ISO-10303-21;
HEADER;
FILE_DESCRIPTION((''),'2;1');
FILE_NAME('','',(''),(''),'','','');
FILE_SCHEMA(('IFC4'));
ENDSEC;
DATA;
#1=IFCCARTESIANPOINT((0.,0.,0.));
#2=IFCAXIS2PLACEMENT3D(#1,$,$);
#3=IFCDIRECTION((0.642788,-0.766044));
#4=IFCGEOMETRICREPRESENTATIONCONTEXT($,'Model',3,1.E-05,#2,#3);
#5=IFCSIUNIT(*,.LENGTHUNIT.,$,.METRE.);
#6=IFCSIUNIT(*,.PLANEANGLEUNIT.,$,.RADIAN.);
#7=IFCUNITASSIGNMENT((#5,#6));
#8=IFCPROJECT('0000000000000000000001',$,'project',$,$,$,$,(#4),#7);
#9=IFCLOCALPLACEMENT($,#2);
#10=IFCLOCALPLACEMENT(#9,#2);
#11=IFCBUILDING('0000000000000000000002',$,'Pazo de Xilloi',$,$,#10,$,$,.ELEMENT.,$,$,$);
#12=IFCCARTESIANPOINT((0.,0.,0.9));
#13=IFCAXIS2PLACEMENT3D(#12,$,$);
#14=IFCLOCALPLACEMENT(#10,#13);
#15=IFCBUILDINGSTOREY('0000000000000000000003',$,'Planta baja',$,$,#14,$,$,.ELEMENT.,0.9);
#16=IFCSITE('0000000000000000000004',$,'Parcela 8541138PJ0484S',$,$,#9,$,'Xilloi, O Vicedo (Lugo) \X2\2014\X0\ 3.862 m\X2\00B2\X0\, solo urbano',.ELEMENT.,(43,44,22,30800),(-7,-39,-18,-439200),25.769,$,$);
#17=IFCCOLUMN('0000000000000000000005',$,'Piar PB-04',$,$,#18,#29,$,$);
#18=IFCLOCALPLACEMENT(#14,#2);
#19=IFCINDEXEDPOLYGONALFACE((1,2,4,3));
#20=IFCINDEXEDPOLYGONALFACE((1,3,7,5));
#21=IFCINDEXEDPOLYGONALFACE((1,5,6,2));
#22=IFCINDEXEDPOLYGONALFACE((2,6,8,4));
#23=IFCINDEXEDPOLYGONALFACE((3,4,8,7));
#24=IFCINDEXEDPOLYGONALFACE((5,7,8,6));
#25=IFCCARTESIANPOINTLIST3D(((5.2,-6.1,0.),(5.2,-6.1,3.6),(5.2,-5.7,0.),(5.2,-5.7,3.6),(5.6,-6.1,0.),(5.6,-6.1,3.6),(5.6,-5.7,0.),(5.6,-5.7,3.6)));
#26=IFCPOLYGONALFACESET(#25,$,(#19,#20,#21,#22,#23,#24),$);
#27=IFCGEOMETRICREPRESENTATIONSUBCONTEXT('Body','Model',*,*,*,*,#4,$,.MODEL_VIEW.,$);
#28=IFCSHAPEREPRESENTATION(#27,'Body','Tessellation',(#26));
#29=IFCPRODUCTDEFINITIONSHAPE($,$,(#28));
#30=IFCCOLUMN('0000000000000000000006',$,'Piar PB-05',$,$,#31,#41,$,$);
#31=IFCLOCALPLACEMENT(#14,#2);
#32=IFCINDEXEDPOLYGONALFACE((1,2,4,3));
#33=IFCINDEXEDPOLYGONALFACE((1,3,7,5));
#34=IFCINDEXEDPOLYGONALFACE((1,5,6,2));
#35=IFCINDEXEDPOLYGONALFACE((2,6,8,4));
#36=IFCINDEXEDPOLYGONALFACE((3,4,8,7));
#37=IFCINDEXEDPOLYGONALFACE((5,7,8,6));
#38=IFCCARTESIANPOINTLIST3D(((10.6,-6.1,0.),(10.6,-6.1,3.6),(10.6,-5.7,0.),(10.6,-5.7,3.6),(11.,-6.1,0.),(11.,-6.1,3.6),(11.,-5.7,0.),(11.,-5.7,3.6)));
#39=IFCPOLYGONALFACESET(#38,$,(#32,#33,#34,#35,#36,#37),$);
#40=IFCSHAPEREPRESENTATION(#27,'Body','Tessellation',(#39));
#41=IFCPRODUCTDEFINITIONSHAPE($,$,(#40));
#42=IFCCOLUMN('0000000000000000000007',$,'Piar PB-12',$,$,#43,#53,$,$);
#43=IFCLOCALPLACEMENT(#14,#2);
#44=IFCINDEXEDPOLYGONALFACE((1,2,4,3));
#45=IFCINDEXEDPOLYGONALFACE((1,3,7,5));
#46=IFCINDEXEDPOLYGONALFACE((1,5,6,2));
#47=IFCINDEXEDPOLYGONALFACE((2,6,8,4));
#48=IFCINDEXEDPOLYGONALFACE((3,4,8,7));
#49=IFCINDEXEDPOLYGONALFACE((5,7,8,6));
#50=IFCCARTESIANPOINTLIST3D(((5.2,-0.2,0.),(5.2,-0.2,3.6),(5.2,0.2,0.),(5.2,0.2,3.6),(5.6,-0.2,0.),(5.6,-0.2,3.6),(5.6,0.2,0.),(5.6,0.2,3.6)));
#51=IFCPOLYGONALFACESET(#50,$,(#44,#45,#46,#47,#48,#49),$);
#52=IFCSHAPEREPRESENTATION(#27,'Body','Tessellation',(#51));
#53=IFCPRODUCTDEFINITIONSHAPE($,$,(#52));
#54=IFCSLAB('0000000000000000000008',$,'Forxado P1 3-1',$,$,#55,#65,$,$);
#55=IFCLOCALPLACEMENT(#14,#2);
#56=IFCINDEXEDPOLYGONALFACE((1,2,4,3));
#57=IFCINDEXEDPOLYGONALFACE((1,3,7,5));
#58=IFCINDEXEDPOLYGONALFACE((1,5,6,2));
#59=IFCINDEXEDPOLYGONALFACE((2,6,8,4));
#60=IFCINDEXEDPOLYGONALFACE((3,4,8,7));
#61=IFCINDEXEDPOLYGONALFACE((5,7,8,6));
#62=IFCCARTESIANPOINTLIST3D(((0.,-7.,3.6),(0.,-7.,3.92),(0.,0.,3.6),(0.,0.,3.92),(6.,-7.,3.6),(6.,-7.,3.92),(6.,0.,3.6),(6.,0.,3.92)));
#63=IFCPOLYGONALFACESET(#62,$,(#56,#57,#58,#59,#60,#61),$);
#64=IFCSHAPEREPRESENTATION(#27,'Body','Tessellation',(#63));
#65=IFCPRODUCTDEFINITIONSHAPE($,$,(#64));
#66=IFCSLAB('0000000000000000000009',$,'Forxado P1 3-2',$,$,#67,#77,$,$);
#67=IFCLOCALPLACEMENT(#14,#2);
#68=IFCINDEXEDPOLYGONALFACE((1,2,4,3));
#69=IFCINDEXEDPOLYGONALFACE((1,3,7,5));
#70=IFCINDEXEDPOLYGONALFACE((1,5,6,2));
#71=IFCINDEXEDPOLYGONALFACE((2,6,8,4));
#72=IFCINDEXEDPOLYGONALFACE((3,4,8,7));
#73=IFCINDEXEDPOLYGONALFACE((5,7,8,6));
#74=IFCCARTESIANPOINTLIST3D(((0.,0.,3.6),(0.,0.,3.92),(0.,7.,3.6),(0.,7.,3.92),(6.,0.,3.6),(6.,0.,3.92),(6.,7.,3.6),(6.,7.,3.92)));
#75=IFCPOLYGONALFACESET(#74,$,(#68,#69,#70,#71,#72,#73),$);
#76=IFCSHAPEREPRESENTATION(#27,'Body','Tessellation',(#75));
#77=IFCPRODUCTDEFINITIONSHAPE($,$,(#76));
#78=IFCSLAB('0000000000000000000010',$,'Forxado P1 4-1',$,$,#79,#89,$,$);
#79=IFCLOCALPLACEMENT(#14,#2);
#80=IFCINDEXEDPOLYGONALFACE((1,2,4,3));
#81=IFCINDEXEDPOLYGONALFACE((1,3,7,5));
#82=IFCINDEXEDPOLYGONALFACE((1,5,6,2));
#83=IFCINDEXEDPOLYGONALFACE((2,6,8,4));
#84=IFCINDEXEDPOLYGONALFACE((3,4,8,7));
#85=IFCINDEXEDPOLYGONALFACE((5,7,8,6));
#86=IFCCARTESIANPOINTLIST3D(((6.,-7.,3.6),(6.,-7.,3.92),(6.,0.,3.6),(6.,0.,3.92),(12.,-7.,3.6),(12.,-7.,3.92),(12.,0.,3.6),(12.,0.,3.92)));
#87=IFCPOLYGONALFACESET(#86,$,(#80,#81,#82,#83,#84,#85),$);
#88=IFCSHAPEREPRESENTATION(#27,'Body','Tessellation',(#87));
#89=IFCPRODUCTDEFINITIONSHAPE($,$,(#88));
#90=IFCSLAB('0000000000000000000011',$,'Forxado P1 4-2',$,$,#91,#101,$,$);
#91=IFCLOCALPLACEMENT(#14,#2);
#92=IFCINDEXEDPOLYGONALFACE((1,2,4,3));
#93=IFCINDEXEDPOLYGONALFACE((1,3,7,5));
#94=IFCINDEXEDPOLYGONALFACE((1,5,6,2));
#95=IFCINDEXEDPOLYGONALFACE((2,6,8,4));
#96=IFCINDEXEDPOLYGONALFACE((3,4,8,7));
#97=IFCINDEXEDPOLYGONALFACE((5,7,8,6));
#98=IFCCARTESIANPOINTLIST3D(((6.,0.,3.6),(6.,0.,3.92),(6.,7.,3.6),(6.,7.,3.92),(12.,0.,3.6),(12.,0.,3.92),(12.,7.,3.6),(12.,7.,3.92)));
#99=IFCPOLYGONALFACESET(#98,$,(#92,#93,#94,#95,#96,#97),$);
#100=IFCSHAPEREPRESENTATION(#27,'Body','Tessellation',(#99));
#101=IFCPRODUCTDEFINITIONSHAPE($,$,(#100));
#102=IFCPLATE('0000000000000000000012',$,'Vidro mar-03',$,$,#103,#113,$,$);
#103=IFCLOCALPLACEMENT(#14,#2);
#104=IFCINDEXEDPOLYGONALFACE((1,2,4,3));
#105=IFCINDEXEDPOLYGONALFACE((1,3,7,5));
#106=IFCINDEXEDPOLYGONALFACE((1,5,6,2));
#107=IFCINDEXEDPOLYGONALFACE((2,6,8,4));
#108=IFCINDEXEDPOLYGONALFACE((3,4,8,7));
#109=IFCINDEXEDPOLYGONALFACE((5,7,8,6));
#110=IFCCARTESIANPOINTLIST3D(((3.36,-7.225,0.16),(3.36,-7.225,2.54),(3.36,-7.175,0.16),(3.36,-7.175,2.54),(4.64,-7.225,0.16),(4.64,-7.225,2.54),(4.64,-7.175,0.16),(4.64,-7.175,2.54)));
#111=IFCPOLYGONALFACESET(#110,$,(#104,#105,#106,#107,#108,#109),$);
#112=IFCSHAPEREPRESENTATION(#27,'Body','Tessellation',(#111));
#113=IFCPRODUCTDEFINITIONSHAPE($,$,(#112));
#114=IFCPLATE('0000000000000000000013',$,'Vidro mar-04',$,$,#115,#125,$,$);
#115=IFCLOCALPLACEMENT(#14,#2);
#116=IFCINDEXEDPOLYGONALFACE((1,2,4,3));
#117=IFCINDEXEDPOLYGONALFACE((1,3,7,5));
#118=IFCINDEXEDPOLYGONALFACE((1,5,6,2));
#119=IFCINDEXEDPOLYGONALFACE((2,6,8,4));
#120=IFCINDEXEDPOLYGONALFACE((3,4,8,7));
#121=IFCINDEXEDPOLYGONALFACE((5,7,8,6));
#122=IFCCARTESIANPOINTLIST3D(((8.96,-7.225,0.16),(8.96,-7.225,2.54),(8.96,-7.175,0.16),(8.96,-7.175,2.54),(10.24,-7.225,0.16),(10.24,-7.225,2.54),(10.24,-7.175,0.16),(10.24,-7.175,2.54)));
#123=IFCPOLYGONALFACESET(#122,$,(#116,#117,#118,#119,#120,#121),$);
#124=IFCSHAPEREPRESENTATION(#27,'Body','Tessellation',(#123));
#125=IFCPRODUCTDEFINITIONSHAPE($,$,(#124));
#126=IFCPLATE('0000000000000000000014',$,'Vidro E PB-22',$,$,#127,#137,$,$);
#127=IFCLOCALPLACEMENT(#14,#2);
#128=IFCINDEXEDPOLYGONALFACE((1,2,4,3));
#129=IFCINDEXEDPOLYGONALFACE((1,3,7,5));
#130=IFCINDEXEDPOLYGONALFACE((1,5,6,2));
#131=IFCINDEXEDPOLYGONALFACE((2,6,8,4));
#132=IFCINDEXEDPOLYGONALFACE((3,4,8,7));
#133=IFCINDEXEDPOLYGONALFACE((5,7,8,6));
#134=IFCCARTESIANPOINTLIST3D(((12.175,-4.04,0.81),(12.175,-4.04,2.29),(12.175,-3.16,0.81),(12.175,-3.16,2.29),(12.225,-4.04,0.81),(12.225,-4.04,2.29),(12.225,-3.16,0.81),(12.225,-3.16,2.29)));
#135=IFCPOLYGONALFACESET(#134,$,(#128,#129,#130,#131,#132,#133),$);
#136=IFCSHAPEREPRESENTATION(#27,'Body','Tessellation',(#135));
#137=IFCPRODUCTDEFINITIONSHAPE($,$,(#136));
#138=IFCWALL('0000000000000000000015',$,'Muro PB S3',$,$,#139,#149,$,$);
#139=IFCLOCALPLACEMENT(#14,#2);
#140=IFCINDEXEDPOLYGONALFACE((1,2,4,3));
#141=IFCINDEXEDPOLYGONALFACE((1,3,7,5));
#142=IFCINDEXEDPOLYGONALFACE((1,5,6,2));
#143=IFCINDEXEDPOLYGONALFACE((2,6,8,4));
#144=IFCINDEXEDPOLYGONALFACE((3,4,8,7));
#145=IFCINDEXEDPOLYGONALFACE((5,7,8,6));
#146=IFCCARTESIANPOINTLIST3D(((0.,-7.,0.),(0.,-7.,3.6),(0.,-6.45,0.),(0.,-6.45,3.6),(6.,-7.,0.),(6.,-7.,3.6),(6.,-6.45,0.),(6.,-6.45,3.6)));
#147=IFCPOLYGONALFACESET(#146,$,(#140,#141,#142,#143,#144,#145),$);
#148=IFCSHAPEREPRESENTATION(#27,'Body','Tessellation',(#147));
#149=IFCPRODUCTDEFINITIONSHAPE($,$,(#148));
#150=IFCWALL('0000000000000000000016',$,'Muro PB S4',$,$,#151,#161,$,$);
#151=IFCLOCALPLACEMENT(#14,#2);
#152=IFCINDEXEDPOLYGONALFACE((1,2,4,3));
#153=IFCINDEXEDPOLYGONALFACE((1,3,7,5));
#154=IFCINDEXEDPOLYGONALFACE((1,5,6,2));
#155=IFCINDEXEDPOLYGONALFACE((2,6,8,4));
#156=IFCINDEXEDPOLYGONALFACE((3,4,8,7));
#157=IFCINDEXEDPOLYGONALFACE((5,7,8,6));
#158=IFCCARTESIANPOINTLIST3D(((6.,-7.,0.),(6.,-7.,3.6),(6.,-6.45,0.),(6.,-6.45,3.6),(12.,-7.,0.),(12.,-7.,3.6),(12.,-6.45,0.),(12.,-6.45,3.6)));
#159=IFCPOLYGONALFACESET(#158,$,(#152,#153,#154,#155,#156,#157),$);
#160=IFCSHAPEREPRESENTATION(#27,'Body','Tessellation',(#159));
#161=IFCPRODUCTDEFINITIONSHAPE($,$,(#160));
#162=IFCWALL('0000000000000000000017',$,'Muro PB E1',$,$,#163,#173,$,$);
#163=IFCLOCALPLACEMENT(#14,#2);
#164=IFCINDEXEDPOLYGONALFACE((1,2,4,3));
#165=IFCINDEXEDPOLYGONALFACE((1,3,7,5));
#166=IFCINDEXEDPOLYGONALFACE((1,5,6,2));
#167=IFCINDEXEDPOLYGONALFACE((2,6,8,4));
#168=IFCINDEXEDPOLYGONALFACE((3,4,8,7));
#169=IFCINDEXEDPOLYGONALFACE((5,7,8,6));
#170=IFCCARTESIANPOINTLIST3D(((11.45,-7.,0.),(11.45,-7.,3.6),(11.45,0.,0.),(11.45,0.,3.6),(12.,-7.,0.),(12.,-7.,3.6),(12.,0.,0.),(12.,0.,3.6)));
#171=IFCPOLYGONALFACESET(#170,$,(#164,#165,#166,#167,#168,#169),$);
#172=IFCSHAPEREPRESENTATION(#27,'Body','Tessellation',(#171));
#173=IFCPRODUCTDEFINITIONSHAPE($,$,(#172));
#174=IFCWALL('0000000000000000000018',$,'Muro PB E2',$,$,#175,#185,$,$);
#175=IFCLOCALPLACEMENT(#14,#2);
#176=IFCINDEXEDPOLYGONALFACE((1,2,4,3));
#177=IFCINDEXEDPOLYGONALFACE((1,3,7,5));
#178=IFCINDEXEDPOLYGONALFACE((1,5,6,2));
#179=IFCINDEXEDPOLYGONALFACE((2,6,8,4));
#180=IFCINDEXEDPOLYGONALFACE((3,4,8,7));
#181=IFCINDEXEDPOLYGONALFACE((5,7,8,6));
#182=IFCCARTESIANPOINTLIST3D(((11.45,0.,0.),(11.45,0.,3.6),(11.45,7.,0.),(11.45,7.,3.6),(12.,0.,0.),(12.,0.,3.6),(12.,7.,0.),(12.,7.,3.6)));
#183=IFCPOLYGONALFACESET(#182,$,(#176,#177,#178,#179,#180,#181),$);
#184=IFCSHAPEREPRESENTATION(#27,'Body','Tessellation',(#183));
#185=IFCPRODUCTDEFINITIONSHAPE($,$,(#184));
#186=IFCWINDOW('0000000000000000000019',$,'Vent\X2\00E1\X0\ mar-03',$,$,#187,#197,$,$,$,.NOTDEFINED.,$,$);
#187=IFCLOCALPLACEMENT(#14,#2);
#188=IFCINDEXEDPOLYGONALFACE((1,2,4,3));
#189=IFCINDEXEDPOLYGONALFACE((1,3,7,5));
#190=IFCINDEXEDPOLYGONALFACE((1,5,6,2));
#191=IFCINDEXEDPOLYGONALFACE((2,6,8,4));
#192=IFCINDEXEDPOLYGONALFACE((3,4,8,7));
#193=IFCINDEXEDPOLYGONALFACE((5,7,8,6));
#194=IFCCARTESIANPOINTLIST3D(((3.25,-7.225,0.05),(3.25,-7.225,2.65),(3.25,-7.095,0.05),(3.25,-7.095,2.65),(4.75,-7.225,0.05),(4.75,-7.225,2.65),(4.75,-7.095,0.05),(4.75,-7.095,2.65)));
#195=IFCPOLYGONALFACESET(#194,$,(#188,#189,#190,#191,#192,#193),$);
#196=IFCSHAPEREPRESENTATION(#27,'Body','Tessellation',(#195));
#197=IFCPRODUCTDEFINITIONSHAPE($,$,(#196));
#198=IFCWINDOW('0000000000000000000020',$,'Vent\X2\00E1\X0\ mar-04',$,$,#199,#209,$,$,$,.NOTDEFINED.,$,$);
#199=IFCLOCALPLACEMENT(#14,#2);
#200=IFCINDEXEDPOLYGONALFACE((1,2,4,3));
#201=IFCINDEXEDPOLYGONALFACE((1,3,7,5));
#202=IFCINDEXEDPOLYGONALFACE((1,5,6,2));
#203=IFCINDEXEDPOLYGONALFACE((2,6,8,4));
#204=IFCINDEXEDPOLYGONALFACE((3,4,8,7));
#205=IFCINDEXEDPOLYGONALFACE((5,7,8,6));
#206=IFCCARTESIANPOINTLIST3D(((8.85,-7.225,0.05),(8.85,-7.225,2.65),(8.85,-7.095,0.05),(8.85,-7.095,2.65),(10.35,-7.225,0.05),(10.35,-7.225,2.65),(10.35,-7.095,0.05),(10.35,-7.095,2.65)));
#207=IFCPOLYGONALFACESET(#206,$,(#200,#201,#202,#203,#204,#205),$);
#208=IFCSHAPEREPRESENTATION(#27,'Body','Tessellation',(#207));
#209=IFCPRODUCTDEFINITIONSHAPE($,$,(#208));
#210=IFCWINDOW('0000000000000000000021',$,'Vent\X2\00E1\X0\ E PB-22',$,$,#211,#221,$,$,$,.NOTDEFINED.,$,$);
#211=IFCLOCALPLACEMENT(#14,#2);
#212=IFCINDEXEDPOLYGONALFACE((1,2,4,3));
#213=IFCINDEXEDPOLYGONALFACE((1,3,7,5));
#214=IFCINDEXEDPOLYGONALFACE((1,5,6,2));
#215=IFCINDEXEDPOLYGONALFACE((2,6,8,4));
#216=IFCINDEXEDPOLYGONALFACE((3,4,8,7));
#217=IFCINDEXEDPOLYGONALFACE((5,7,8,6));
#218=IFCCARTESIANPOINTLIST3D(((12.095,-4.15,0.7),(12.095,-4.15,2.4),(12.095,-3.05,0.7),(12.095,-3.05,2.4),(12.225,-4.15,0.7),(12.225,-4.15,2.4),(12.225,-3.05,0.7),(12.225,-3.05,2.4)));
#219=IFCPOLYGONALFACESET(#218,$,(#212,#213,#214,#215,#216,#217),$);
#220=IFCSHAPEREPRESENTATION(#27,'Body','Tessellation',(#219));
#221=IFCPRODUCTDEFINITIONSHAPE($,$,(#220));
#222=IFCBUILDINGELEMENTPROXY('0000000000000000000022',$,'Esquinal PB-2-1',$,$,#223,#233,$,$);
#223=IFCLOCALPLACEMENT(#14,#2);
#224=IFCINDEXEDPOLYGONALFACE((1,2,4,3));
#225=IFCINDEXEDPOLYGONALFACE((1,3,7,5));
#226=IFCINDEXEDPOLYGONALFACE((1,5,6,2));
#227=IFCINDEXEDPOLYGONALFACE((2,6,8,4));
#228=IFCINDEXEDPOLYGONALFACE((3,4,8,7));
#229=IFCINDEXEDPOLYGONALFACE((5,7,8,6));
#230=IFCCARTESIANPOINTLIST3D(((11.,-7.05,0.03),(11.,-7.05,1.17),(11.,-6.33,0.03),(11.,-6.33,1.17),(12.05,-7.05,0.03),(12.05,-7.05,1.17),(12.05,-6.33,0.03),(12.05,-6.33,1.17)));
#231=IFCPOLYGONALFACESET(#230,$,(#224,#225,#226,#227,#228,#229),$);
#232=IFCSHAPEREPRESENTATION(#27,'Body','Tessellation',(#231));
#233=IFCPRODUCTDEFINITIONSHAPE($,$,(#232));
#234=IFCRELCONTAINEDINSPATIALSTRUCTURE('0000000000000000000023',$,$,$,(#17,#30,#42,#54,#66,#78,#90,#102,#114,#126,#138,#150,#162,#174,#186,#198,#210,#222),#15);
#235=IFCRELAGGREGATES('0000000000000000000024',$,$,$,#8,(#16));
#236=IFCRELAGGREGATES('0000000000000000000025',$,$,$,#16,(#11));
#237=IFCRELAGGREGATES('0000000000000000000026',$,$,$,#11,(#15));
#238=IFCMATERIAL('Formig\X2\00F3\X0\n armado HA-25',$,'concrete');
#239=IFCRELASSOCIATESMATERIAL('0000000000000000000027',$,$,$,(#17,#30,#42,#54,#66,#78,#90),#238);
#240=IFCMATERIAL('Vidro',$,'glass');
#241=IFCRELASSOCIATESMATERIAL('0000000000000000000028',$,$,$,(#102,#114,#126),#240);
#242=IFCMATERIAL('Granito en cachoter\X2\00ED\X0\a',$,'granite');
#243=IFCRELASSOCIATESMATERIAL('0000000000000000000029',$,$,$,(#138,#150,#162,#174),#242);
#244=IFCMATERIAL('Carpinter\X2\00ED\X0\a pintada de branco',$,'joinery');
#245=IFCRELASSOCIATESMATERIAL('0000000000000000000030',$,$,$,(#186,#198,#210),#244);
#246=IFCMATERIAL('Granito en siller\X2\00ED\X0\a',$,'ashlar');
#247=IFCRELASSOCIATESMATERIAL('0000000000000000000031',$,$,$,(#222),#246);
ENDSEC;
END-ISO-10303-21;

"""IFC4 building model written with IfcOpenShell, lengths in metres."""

from ifc_helpers import new_model, si_unit, direction, frame, origin, origin_2d, place, context, subcontext, project, spatial, rectangle, extrude, material, element, save


model = new_model("IFC4")

# Units and contexts
model_context = context("Model", 3, precision=1e-05, world=origin(), true_north=direction((0.642788, -0.766044)))
body_context = subcontext(model_context, "Body", "Model", "MODEL_VIEW")
ifc_project = project(units=[si_unit("LENGTHUNIT", "METRE"), si_unit("PLANEANGLEUNIT", "RADIAN")], contexts=[model_context])

# Site, building, storey
site_placement = place(None, origin())
site = spatial("IfcSite", under=ifc_project, at=site_placement, Name="Parcela 8541138PJ0484S", LongName="Xilloi, O Vicedo (Lugo) — 3.862 m², solo urbano", CompositionType="ELEMENT", RefLatitude=(43, 44, 22, 30800), RefLongitude=(-7, -39, -18, -439200), RefElevation=25.769)
building_placement = place(site_placement, origin())
building = spatial("IfcBuilding", under=site, at=building_placement, Name="Pazo de Xilloi", CompositionType="ELEMENT")
storey_placement = place(building_placement, frame((0.0, 0.0, 0.9)))
storey = spatial("IfcBuildingStorey", under=building, at=storey_placement, Name="Planta baja", CompositionType="ELEMENT", Elevation=0.9)

# Columns
ifc_material_1 = material(Name="Formigón armado HA-25", Category="concrete")
for number, where, name in (
    (1, (5.4, -5.9, 1.8), "Piar PB-04"),
    (2, (10.8, -5.9, 1.8), "Piar PB-05"),
    (3, (5.4, 0.0, 1.8), "Piar PB-12"),
):
    element("IfcColumn", number, at=place(storey_placement, frame(where)), inside=storey, material=ifc_material_1, Name=name, context=body_context, shape_type="SweptSolid", body=[
        extrude(rectangle(XDim=0.4, YDim=0.4, at=origin_2d()), frame((0.0, 0.0, -1.8)), (0.0, 0.0, 1.0), 3.6),
    ])

# Slabs
for number, where, name in (
    (4, (3.0, -3.5, 3.76), "Forxado P1 3-1"),
    (5, (3.0, 3.5, 3.76), "Forxado P1 3-2"),
    (6, (9.0, -3.5, 3.76), "Forxado P1 4-1"),
    (7, (9.0, 3.5, 3.76), "Forxado P1 4-2"),
):
    element("IfcSlab", number, at=place(storey_placement, frame(where)), inside=storey, material=ifc_material_1, Name=name, context=body_context, shape_type="SweptSolid", body=[
        extrude(rectangle(XDim=6.0, YDim=7.0, at=origin_2d()), frame((0.0, 0.0, -0.16)), (0.0, 0.0, 1.0), 0.32),
    ])

# Plates
ifc_material_2 = material(Name="Vidro", Category="glass")
for number, where, name in (
    (8, (4.0, -7.2, 1.35), "Vidro mar-03"),
    (9, (9.6, -7.2, 1.35), "Vidro mar-04"),
):
    element("IfcPlate", number, at=place(storey_placement, frame(where)), inside=storey, material=ifc_material_2, Name=name, context=body_context, shape_type="SweptSolid", body=[
        extrude(rectangle(XDim=1.28, YDim=0.05, at=origin_2d()), frame((0.0, 0.0, -1.19)), (0.0, 0.0, 1.0), 2.38),
    ])
plate_placement = place(storey_placement, frame((12.2, -3.6, 1.55)))
element("IfcPlate", 10, at=plate_placement, inside=storey, material=ifc_material_2, Name="Vidro E PB-22", context=body_context, shape_type="SweptSolid", body=[
    extrude(rectangle(XDim=0.05, YDim=0.88, at=origin_2d()), frame((0.0, 0.0, -0.74)), (0.0, 0.0, 1.0), 1.48),
])

# Walls
ifc_material_3 = material(Name="Granito en cachotería", Category="granite")
for number, where, name in (
    (11, (3.0, -6.725, 1.8), "Muro PB S3"),
    (12, (9.0, -6.725, 1.8), "Muro PB S4"),
):
    element("IfcWall", number, at=place(storey_placement, frame(where)), inside=storey, material=ifc_material_3, Name=name, context=body_context, shape_type="SweptSolid", body=[
        extrude(rectangle(XDim=6.0, YDim=0.55, at=origin_2d()), frame((0.0, 0.0, -1.8)), (0.0, 0.0, 1.0), 3.6),
    ])
for number, where, name in (
    (13, (11.725, -3.5, 1.8), "Muro PB E1"),
    (14, (11.725, 3.5, 1.8), "Muro PB E2"),
):
    element("IfcWall", number, at=place(storey_placement, frame(where)), inside=storey, material=ifc_material_3, Name=name, context=body_context, shape_type="SweptSolid", body=[
        extrude(rectangle(XDim=0.55, YDim=7.0, at=origin_2d()), frame((0.0, 0.0, -1.8)), (0.0, 0.0, 1.0), 3.6),
    ])

# Windows
ifc_material_4 = material(Name="Carpintería pintada de branco", Category="joinery")
for number, where, name in (
    (15, (4.0, -7.16, 1.35), "Ventá mar-03"),
    (16, (9.6, -7.16, 1.35), "Ventá mar-04"),
):
    element("IfcWindow", number, at=place(storey_placement, frame(where)), inside=storey, material=ifc_material_4, Name=name, PredefinedType="NOTDEFINED", context=body_context, shape_type="SweptSolid", body=[
        extrude(rectangle(XDim=1.5, YDim=0.13, at=origin_2d()), frame((0.0, 0.0, -1.3)), (0.0, 0.0, 1.0), 2.6),
    ])
window_placement = place(storey_placement, frame((12.16, -3.6, 1.55)))
element("IfcWindow", 17, at=window_placement, inside=storey, material=ifc_material_4, Name="Ventá E PB-22", PredefinedType="NOTDEFINED", context=body_context, shape_type="SweptSolid", body=[
    extrude(rectangle(XDim=0.13, YDim=1.1, at=origin_2d()), frame((0.0, 0.0, -0.85)), (0.0, 0.0, 1.0), 1.7),
])

# Building element proxy
ifc_material_5 = material(Name="Granito en sillería", Category="ashlar")
proxy_1_placement = place(storey_placement, frame((11.525, -6.69, 0.6)))
element("IfcBuildingElementProxy", 18, at=proxy_1_placement, inside=storey, material=ifc_material_5, Name="Esquinal PB-2-1", context=body_context, shape_type="SweptSolid", body=[
    extrude(rectangle(XDim=1.05, YDim=0.72, at=origin_2d()), frame((0.0, 0.0, -0.57)), (0.0, 0.0, 1.0), 1.14),
])

save(model, "model.ifc")
